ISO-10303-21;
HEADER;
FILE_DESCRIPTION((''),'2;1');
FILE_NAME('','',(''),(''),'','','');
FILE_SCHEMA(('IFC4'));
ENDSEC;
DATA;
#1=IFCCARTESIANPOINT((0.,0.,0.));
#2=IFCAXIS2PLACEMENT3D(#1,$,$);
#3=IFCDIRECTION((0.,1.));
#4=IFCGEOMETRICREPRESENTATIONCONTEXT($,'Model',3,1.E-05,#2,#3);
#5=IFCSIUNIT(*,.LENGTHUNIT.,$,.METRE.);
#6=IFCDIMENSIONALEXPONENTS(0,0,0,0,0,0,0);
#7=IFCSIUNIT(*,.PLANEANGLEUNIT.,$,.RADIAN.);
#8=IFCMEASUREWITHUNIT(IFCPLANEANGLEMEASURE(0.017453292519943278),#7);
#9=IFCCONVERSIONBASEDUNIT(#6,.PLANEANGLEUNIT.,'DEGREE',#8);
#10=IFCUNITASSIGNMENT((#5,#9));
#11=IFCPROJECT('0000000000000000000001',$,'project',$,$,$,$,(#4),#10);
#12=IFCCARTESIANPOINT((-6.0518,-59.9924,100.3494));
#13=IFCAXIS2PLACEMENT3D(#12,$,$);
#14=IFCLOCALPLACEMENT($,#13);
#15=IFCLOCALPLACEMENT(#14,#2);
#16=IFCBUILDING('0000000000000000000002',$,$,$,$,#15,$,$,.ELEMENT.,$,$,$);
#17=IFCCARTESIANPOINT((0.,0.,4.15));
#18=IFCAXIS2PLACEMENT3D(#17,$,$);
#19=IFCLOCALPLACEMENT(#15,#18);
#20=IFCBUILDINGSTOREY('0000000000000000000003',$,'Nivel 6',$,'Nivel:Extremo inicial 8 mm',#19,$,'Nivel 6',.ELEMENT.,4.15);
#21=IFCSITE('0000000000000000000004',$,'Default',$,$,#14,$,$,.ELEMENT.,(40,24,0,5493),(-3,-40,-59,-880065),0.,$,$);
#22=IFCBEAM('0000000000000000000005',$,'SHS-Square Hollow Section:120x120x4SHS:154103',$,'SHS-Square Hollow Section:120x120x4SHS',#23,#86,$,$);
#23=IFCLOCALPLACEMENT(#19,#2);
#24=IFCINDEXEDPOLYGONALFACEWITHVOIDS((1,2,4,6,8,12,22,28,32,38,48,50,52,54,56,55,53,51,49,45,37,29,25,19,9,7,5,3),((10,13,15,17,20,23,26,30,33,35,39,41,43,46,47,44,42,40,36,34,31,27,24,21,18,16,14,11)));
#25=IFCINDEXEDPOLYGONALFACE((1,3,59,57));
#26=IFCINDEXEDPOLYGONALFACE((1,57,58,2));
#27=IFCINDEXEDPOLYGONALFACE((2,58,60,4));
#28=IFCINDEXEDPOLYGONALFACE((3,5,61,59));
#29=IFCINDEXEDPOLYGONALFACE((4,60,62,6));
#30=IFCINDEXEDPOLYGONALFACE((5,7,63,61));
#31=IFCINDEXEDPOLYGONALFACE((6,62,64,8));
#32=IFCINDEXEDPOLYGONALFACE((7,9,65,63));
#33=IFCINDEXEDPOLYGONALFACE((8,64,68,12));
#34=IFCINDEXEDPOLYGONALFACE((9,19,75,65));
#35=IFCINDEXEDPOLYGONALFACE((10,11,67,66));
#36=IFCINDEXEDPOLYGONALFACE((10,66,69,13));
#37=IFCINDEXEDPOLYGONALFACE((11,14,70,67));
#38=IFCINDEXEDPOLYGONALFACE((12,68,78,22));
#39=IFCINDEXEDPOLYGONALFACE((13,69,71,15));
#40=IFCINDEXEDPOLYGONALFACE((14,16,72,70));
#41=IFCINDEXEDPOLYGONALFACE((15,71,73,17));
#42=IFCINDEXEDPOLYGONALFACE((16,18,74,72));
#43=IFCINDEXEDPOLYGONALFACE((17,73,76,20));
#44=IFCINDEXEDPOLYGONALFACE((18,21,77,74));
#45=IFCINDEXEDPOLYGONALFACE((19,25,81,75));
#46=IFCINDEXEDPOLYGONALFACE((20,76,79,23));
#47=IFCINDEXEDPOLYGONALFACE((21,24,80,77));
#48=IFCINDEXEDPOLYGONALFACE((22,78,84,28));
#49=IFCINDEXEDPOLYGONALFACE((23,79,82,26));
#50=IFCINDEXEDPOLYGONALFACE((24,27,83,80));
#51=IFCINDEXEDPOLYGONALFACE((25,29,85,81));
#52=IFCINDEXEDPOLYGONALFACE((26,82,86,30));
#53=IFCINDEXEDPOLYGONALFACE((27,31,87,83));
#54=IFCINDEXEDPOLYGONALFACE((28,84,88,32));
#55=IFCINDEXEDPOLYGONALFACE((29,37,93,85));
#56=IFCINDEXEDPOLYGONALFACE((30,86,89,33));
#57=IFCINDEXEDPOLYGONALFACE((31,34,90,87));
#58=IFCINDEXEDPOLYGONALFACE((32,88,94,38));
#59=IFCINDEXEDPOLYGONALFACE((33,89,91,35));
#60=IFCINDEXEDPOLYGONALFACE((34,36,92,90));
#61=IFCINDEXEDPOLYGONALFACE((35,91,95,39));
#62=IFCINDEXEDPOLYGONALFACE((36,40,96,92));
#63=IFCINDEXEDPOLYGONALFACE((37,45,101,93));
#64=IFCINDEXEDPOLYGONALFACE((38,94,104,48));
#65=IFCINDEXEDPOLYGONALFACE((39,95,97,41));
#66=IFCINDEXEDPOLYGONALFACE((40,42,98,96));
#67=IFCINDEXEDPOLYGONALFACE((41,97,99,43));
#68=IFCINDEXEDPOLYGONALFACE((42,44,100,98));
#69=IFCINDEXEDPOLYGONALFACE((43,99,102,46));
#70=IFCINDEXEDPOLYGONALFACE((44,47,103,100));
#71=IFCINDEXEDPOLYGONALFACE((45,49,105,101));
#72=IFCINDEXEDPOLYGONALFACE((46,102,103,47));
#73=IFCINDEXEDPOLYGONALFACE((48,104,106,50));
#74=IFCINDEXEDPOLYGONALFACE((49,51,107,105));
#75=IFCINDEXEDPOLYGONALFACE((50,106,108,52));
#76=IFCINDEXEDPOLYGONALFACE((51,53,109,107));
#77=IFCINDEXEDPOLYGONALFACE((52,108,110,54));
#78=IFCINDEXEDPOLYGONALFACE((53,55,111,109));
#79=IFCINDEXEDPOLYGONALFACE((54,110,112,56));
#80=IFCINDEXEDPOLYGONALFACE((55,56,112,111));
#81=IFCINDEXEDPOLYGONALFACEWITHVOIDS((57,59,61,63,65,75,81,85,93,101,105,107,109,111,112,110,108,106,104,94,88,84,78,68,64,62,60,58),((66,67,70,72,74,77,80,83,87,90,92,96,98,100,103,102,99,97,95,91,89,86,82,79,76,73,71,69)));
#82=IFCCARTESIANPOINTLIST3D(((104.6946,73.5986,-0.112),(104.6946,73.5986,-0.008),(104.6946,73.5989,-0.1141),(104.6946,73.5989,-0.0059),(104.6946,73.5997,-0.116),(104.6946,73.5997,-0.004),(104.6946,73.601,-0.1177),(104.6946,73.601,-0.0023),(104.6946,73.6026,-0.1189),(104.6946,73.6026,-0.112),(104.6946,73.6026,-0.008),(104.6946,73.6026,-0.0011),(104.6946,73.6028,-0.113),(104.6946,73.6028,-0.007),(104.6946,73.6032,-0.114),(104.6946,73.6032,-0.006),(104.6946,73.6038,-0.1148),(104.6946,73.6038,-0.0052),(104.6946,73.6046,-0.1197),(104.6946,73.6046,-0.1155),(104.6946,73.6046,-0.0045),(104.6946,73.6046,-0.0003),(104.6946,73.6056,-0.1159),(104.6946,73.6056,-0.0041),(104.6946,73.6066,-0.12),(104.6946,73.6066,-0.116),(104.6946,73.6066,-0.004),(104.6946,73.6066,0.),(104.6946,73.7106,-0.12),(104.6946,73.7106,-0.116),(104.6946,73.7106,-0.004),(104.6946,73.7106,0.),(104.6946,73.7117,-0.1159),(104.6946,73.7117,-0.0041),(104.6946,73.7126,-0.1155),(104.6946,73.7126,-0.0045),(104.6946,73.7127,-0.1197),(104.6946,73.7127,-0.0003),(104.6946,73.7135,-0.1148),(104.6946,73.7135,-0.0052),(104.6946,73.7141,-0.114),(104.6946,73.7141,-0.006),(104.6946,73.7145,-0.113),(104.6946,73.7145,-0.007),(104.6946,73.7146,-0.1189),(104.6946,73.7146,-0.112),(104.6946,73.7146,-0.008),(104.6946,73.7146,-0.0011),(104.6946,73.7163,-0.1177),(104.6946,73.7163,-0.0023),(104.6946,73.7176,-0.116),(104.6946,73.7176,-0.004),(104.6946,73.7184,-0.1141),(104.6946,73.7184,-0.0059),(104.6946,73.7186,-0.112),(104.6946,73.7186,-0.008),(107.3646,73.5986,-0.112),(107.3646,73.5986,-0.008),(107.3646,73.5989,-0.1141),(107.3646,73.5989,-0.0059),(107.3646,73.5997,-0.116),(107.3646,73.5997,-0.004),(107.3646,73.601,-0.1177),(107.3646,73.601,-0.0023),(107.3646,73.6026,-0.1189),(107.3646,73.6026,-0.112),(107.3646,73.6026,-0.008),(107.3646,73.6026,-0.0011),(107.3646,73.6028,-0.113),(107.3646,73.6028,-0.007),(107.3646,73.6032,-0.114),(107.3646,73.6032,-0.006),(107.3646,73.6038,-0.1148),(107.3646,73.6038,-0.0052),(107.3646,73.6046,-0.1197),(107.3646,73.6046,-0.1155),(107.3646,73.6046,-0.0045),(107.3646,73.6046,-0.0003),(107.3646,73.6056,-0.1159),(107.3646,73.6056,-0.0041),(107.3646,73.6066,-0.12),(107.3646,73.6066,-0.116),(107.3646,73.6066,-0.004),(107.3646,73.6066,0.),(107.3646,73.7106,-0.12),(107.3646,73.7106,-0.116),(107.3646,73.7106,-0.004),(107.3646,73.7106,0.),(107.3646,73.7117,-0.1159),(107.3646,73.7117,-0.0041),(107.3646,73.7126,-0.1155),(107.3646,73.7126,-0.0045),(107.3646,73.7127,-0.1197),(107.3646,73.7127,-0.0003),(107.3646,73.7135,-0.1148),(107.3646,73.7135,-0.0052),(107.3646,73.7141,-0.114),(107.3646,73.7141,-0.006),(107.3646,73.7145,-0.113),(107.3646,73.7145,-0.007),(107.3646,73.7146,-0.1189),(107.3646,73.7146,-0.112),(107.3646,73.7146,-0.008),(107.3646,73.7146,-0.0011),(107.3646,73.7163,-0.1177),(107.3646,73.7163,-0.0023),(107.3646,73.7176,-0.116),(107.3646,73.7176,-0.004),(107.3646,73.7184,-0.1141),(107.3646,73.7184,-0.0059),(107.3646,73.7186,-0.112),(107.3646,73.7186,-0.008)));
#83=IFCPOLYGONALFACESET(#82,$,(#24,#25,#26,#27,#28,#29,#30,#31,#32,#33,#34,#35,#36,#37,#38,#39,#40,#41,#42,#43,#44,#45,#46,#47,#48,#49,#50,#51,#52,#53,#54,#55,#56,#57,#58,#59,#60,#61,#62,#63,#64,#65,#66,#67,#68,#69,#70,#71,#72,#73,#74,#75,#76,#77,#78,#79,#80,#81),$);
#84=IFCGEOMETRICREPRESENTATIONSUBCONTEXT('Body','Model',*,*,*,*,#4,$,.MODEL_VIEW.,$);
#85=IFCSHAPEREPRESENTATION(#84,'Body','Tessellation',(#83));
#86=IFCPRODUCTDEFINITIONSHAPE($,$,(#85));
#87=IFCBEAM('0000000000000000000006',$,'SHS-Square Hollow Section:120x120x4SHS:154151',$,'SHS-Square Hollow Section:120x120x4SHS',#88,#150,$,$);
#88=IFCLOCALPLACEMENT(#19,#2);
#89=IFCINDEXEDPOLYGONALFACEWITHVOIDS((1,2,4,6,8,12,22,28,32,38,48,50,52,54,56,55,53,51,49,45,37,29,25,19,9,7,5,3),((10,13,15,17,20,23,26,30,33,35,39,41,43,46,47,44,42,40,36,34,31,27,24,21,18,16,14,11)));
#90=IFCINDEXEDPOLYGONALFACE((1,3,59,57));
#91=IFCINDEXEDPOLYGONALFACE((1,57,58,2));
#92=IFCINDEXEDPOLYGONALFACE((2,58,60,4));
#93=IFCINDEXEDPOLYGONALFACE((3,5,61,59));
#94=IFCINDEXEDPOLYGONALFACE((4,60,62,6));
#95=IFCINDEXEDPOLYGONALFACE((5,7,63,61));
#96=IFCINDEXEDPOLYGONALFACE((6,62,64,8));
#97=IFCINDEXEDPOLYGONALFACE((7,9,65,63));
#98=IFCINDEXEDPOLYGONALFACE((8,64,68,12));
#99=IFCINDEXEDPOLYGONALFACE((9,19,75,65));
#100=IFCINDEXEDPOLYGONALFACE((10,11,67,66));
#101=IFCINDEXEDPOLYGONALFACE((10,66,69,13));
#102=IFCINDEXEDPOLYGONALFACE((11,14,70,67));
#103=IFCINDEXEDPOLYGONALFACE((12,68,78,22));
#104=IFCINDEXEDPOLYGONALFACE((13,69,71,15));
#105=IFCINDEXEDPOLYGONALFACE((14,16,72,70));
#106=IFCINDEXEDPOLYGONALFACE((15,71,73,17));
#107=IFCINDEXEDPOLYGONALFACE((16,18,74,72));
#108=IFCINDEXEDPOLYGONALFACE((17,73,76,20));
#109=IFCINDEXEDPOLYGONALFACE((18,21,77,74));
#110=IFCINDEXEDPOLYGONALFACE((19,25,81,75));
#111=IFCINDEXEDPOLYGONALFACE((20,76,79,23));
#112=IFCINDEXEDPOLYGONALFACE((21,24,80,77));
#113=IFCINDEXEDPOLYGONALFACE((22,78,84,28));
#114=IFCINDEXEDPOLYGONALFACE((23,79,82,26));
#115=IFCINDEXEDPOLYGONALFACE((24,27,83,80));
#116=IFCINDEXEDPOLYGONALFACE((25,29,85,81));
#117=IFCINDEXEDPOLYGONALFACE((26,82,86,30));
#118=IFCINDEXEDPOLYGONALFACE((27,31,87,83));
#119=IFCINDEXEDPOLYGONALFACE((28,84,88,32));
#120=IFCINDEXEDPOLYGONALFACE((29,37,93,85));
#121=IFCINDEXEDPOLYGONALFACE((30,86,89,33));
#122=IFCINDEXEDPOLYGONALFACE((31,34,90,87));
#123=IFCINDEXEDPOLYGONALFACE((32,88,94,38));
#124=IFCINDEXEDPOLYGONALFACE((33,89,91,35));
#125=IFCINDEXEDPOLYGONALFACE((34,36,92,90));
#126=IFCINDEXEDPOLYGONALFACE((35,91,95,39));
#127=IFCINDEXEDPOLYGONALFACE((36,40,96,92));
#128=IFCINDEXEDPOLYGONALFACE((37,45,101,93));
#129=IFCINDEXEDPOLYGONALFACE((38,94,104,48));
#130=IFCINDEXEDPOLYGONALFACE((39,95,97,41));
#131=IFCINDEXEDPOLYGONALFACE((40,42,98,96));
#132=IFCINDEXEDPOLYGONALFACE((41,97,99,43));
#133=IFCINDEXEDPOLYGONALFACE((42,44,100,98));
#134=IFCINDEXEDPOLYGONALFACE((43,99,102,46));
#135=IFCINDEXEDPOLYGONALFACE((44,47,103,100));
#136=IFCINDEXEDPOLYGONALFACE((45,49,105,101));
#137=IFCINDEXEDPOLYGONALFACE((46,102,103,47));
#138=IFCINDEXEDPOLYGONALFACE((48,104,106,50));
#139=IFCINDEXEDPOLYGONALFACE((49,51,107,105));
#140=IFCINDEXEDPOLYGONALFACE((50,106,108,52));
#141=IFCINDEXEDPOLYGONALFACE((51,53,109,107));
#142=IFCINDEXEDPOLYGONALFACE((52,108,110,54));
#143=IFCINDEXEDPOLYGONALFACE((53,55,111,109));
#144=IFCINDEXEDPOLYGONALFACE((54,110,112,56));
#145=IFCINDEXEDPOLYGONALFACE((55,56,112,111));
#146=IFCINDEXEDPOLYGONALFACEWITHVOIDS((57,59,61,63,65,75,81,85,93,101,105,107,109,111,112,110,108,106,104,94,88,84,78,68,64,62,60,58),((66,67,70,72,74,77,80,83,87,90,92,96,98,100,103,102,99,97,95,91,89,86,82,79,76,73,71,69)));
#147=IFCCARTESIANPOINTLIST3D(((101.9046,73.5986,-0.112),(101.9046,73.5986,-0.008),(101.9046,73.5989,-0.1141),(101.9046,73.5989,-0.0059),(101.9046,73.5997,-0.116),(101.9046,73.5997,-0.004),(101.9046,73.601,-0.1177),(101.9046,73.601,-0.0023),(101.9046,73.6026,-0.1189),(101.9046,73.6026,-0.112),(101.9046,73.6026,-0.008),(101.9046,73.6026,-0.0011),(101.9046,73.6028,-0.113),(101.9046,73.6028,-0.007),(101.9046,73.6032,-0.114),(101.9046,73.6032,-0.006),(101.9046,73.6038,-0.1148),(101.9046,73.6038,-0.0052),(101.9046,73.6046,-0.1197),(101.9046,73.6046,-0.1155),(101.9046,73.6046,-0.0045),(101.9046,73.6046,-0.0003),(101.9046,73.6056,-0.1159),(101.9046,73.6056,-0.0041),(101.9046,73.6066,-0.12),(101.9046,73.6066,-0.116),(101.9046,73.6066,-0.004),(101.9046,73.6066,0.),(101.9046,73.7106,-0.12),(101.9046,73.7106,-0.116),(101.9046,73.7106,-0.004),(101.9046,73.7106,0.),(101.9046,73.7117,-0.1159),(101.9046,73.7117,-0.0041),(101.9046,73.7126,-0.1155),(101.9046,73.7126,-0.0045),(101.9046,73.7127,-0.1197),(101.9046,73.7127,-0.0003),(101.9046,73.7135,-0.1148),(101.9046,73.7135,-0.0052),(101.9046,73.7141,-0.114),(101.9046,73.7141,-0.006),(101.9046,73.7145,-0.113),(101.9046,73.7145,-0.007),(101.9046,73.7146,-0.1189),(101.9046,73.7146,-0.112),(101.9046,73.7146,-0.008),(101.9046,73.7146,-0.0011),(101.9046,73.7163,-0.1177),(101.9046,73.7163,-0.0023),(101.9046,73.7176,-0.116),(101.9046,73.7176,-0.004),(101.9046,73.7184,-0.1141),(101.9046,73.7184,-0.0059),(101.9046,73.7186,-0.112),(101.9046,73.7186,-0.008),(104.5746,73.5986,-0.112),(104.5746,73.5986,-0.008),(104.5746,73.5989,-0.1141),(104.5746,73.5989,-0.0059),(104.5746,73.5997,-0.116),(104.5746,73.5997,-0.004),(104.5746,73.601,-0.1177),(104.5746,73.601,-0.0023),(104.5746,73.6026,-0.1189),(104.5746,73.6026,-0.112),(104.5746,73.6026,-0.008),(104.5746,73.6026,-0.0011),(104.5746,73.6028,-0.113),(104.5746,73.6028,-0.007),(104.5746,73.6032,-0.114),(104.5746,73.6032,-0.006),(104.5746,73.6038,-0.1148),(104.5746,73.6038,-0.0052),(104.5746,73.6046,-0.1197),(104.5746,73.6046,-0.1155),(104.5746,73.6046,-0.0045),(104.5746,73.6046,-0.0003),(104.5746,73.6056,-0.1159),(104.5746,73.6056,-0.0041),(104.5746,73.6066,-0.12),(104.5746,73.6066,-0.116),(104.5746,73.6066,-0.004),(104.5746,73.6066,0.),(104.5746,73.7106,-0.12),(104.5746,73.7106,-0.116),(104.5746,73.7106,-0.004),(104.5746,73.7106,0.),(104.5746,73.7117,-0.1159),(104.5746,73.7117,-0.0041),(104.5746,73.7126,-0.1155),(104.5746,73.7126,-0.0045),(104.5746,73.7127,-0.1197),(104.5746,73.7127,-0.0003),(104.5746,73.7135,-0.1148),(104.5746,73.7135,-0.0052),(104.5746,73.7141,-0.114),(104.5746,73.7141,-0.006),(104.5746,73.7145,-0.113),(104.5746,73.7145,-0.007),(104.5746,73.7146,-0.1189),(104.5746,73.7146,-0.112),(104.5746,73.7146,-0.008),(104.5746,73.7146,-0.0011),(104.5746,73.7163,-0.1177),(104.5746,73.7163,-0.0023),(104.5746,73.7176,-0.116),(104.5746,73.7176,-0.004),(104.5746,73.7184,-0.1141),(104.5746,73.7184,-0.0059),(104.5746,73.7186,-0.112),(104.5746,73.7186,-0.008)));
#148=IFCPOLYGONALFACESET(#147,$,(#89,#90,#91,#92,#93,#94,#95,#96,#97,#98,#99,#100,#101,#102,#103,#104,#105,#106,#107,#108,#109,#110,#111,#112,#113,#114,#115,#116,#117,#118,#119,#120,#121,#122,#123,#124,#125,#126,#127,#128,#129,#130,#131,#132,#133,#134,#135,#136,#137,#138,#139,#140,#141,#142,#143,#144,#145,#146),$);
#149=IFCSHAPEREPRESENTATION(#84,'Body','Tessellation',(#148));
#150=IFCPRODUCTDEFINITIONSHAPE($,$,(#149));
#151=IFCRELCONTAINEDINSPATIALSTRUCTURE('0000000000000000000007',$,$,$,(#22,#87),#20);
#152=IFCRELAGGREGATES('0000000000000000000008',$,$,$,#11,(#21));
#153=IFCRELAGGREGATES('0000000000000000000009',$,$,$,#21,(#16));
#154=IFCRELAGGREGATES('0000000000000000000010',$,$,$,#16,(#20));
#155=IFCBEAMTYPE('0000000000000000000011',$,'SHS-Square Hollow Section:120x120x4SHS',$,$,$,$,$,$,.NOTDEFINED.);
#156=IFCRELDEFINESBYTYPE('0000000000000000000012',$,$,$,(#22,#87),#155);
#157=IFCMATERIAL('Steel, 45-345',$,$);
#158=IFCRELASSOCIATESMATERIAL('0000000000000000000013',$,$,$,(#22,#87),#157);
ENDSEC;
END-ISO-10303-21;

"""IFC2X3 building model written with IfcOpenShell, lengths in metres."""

from ifc_helpers import new_model, entity, si_unit, converted_unit, direction, frame, frame_2d, origin, place, context, subcontext, project, spatial, polyline, circle_curve, parameter, trimmed, segment, composite_curve, outline, extrude, material, type_object, element, save


model = new_model("IFC2X3")

# Units and contexts
model_context = context("Model", 3, precision=1e-05, world=origin(), true_north=direction((0.0, 1.0)))
body_context = subcontext(model_context, "Body", "Model", "MODEL_VIEW")
ifc_project = project(units=[si_unit("LENGTHUNIT", "METRE"), converted_unit("PLANEANGLEUNIT", "DEGREE", entity("IfcPlaneAngleMeasure", 0.017453292519943278), si_unit("PLANEANGLEUNIT", "RADIAN"), dimensions=[0, 0, 0, 0, 0, 0, 0])], contexts=[model_context])

# Site, building, storey
site_placement = place(None, frame((-6.0518, -59.9924, 100.3494)))
site = spatial("IfcSite", under=ifc_project, at=site_placement, Name="Default", CompositionType="ELEMENT", RefLatitude=(40, 24, 0, 5493), RefLongitude=(-3, -40, -59, -880065), RefElevation=0.0)
building_placement = place(site_placement, origin())
building = spatial("IfcBuilding", under=site, at=building_placement, CompositionType="ELEMENT")
storey_placement = place(building_placement, frame((0.0, 0.0, 4.15)))
storey = spatial("IfcBuildingStorey", under=building, at=storey_placement, Name="Nivel 6", ObjectType="Nivel:Extremo inicial 8 mm", LongName="Nivel 6", CompositionType="ELEMENT", Elevation=4.15)

# Beams
ifc_material_1 = material(Name="Steel, 45-345")
beam_type_1 = type_object("IfcBeamType", Name="SHS-Square Hollow Section:120x120x4SHS", PredefinedType="NOTDEFINED")
beam_1_placement = place(storey_placement, frame((107.3646, 73.6586, 0.0), z_axis=(0.0, 0.0, 1.0), x_axis=(-1.0, 0.0, 0.0)))
element("IfcBeam", 1, at=beam_1_placement, inside=storey, type_object=beam_type_1, material=ifc_material_1, Name="SHS-Square Hollow Section:120x120x4SHS:154103", ObjectType="SHS-Square Hollow Section:120x120x4SHS", context=body_context, shape_type="SweptSolid", body=[
    extrude(outline(composite_curve([segment(trimmed(circle_curve(frame_2d((-0.052, -0.052), x_axis=(1.0, 0.0)), 0.008), [parameter(180.0)], [parameter(270.0)], True, "PARAMETER"), True, "CONTINUOUS"), segment(polyline([(-0.052, -0.06), (0.052, -0.06)]), True, "CONTINUOUS"), segment(trimmed(circle_curve(frame_2d((0.052, -0.052), x_axis=(1.0, 0.0)), 0.008), [parameter(270.0)], [parameter(0.0)], True, "PARAMETER"), True, "CONTINUOUS"), segment(polyline([(0.06, -0.052), (0.06, 0.052)]), True, "CONTINUOUS"), segment(trimmed(circle_curve(frame_2d((0.052, 0.052), x_axis=(1.0, 0.0)), 0.008), [parameter(360.0)], [parameter(90.0)], True, "PARAMETER"), True, "CONTINUOUS"), segment(polyline([(0.052, 0.06), (-0.052, 0.06)]), True, "CONTINUOUS"), segment(trimmed(circle_curve(frame_2d((-0.052, 0.052), x_axis=(1.0, 0.0)), 0.008), [parameter(90.0)], [parameter(180.0)], True, "PARAMETER"), True, "CONTINUOUS"), segment(polyline([(-0.06, 0.052), (-0.06, -0.052)]), True, "CONTINUOUS")], self_intersect=False), holes=[composite_curve([segment(polyline([(0.052, -0.056), (-0.052, -0.056)]), True, "CONTINUOUS"), segment(trimmed(circle_curve(frame_2d((-0.052, -0.052), x_axis=(1.0, 0.0)), 0.004), [parameter(180.0)], [parameter(270.0)], True, "PARAMETER"), False, "CONTINUOUS"), segment(polyline([(-0.056, -0.052), (-0.056, 0.052)]), True, "CONTINUOUS"), segment(trimmed(circle_curve(frame_2d((-0.052, 0.052), x_axis=(1.0, 0.0)), 0.004), [parameter(90.0)], [parameter(180.0)], True, "PARAMETER"), False, "CONTINUOUS"), segment(polyline([(-0.052, 0.056), (0.052, 0.056)]), True, "CONTINUOUS"), segment(trimmed(circle_curve(frame_2d((0.052, 0.052), x_axis=(1.0, 0.0)), 0.004), [parameter(0.0)], [parameter(90.0)], True, "PARAMETER"), False, "CONTINUOUS"), segment(polyline([(0.056, 0.052), (0.056, -0.052)]), True, "CONTINUOUS"), segment(trimmed(circle_curve(frame_2d((0.052, -0.052), x_axis=(1.0, 0.0)), 0.004), [parameter(270.0)], [parameter(0.0)], True, "PARAMETER"), False, "CONTINUOUS")], self_intersect=False)]), frame((0.0, 0.0, -0.06), z_axis=(1.0, 0.0, 0.0), x_axis=(0.0, -1.0, 0.0)), (0.0, 0.0, 1.0), 2.67),
])
beam_2_placement = place(storey_placement, frame((104.5746, 73.6586, 0.0), z_axis=(0.0, 0.0, 1.0), x_axis=(-1.0, 0.0, 0.0)))
element("IfcBeam", 2, at=beam_2_placement, inside=storey, type_object=beam_type_1, material=ifc_material_1, Name="SHS-Square Hollow Section:120x120x4SHS:154151", ObjectType="SHS-Square Hollow Section:120x120x4SHS", context=body_context, shape_type="SweptSolid", body=[
    extrude(outline(composite_curve([segment(trimmed(circle_curve(frame_2d((-0.052, -0.052), x_axis=(1.0, 0.0)), 0.008), [parameter(180.0)], [parameter(270.0)], True, "PARAMETER"), True, "CONTINUOUS"), segment(polyline([(-0.052, -0.06), (0.052, -0.06)]), True, "CONTINUOUS"), segment(trimmed(circle_curve(frame_2d((0.052, -0.052), x_axis=(1.0, 0.0)), 0.008), [parameter(270.0)], [parameter(0.0)], True, "PARAMETER"), True, "CONTINUOUS"), segment(polyline([(0.06, -0.052), (0.06, 0.052)]), True, "CONTINUOUS"), segment(trimmed(circle_curve(frame_2d((0.052, 0.052), x_axis=(1.0, 0.0)), 0.008), [parameter(360.0)], [parameter(90.0)], True, "PARAMETER"), True, "CONTINUOUS"), segment(polyline([(0.052, 0.06), (-0.052, 0.06)]), True, "CONTINUOUS"), segment(trimmed(circle_curve(frame_2d((-0.052, 0.052), x_axis=(1.0, 0.0)), 0.008), [parameter(90.0)], [parameter(180.0)], True, "PARAMETER"), True, "CONTINUOUS"), segment(polyline([(-0.06, 0.052), (-0.06, -0.052)]), True, "CONTINUOUS")], self_intersect=False), holes=[composite_curve([segment(polyline([(0.052, -0.056), (-0.052, -0.056)]), True, "CONTINUOUS"), segment(trimmed(circle_curve(frame_2d((-0.052, -0.052), x_axis=(1.0, 0.0)), 0.004), [parameter(180.0)], [parameter(270.0)], True, "PARAMETER"), False, "CONTINUOUS"), segment(polyline([(-0.056, -0.052), (-0.056, 0.052)]), True, "CONTINUOUS"), segment(trimmed(circle_curve(frame_2d((-0.052, 0.052), x_axis=(1.0, 0.0)), 0.004), [parameter(90.0)], [parameter(180.0)], True, "PARAMETER"), False, "CONTINUOUS"), segment(polyline([(-0.052, 0.056), (0.052, 0.056)]), True, "CONTINUOUS"), segment(trimmed(circle_curve(frame_2d((0.052, 0.052), x_axis=(1.0, 0.0)), 0.004), [parameter(0.0)], [parameter(90.0)], True, "PARAMETER"), False, "CONTINUOUS"), segment(polyline([(0.056, 0.052), (0.056, -0.052)]), True, "CONTINUOUS"), segment(trimmed(circle_curve(frame_2d((0.052, -0.052), x_axis=(1.0, 0.0)), 0.004), [parameter(270.0)], [parameter(0.0)], True, "PARAMETER"), False, "CONTINUOUS")], self_intersect=False)]), frame((0.0, 0.0, -0.06), z_axis=(1.0, 0.0, 0.0), x_axis=(0.0, -1.0, 0.0)), (0.0, 0.0, 1.0), 2.67),
])

save(model, "model.ifc")
